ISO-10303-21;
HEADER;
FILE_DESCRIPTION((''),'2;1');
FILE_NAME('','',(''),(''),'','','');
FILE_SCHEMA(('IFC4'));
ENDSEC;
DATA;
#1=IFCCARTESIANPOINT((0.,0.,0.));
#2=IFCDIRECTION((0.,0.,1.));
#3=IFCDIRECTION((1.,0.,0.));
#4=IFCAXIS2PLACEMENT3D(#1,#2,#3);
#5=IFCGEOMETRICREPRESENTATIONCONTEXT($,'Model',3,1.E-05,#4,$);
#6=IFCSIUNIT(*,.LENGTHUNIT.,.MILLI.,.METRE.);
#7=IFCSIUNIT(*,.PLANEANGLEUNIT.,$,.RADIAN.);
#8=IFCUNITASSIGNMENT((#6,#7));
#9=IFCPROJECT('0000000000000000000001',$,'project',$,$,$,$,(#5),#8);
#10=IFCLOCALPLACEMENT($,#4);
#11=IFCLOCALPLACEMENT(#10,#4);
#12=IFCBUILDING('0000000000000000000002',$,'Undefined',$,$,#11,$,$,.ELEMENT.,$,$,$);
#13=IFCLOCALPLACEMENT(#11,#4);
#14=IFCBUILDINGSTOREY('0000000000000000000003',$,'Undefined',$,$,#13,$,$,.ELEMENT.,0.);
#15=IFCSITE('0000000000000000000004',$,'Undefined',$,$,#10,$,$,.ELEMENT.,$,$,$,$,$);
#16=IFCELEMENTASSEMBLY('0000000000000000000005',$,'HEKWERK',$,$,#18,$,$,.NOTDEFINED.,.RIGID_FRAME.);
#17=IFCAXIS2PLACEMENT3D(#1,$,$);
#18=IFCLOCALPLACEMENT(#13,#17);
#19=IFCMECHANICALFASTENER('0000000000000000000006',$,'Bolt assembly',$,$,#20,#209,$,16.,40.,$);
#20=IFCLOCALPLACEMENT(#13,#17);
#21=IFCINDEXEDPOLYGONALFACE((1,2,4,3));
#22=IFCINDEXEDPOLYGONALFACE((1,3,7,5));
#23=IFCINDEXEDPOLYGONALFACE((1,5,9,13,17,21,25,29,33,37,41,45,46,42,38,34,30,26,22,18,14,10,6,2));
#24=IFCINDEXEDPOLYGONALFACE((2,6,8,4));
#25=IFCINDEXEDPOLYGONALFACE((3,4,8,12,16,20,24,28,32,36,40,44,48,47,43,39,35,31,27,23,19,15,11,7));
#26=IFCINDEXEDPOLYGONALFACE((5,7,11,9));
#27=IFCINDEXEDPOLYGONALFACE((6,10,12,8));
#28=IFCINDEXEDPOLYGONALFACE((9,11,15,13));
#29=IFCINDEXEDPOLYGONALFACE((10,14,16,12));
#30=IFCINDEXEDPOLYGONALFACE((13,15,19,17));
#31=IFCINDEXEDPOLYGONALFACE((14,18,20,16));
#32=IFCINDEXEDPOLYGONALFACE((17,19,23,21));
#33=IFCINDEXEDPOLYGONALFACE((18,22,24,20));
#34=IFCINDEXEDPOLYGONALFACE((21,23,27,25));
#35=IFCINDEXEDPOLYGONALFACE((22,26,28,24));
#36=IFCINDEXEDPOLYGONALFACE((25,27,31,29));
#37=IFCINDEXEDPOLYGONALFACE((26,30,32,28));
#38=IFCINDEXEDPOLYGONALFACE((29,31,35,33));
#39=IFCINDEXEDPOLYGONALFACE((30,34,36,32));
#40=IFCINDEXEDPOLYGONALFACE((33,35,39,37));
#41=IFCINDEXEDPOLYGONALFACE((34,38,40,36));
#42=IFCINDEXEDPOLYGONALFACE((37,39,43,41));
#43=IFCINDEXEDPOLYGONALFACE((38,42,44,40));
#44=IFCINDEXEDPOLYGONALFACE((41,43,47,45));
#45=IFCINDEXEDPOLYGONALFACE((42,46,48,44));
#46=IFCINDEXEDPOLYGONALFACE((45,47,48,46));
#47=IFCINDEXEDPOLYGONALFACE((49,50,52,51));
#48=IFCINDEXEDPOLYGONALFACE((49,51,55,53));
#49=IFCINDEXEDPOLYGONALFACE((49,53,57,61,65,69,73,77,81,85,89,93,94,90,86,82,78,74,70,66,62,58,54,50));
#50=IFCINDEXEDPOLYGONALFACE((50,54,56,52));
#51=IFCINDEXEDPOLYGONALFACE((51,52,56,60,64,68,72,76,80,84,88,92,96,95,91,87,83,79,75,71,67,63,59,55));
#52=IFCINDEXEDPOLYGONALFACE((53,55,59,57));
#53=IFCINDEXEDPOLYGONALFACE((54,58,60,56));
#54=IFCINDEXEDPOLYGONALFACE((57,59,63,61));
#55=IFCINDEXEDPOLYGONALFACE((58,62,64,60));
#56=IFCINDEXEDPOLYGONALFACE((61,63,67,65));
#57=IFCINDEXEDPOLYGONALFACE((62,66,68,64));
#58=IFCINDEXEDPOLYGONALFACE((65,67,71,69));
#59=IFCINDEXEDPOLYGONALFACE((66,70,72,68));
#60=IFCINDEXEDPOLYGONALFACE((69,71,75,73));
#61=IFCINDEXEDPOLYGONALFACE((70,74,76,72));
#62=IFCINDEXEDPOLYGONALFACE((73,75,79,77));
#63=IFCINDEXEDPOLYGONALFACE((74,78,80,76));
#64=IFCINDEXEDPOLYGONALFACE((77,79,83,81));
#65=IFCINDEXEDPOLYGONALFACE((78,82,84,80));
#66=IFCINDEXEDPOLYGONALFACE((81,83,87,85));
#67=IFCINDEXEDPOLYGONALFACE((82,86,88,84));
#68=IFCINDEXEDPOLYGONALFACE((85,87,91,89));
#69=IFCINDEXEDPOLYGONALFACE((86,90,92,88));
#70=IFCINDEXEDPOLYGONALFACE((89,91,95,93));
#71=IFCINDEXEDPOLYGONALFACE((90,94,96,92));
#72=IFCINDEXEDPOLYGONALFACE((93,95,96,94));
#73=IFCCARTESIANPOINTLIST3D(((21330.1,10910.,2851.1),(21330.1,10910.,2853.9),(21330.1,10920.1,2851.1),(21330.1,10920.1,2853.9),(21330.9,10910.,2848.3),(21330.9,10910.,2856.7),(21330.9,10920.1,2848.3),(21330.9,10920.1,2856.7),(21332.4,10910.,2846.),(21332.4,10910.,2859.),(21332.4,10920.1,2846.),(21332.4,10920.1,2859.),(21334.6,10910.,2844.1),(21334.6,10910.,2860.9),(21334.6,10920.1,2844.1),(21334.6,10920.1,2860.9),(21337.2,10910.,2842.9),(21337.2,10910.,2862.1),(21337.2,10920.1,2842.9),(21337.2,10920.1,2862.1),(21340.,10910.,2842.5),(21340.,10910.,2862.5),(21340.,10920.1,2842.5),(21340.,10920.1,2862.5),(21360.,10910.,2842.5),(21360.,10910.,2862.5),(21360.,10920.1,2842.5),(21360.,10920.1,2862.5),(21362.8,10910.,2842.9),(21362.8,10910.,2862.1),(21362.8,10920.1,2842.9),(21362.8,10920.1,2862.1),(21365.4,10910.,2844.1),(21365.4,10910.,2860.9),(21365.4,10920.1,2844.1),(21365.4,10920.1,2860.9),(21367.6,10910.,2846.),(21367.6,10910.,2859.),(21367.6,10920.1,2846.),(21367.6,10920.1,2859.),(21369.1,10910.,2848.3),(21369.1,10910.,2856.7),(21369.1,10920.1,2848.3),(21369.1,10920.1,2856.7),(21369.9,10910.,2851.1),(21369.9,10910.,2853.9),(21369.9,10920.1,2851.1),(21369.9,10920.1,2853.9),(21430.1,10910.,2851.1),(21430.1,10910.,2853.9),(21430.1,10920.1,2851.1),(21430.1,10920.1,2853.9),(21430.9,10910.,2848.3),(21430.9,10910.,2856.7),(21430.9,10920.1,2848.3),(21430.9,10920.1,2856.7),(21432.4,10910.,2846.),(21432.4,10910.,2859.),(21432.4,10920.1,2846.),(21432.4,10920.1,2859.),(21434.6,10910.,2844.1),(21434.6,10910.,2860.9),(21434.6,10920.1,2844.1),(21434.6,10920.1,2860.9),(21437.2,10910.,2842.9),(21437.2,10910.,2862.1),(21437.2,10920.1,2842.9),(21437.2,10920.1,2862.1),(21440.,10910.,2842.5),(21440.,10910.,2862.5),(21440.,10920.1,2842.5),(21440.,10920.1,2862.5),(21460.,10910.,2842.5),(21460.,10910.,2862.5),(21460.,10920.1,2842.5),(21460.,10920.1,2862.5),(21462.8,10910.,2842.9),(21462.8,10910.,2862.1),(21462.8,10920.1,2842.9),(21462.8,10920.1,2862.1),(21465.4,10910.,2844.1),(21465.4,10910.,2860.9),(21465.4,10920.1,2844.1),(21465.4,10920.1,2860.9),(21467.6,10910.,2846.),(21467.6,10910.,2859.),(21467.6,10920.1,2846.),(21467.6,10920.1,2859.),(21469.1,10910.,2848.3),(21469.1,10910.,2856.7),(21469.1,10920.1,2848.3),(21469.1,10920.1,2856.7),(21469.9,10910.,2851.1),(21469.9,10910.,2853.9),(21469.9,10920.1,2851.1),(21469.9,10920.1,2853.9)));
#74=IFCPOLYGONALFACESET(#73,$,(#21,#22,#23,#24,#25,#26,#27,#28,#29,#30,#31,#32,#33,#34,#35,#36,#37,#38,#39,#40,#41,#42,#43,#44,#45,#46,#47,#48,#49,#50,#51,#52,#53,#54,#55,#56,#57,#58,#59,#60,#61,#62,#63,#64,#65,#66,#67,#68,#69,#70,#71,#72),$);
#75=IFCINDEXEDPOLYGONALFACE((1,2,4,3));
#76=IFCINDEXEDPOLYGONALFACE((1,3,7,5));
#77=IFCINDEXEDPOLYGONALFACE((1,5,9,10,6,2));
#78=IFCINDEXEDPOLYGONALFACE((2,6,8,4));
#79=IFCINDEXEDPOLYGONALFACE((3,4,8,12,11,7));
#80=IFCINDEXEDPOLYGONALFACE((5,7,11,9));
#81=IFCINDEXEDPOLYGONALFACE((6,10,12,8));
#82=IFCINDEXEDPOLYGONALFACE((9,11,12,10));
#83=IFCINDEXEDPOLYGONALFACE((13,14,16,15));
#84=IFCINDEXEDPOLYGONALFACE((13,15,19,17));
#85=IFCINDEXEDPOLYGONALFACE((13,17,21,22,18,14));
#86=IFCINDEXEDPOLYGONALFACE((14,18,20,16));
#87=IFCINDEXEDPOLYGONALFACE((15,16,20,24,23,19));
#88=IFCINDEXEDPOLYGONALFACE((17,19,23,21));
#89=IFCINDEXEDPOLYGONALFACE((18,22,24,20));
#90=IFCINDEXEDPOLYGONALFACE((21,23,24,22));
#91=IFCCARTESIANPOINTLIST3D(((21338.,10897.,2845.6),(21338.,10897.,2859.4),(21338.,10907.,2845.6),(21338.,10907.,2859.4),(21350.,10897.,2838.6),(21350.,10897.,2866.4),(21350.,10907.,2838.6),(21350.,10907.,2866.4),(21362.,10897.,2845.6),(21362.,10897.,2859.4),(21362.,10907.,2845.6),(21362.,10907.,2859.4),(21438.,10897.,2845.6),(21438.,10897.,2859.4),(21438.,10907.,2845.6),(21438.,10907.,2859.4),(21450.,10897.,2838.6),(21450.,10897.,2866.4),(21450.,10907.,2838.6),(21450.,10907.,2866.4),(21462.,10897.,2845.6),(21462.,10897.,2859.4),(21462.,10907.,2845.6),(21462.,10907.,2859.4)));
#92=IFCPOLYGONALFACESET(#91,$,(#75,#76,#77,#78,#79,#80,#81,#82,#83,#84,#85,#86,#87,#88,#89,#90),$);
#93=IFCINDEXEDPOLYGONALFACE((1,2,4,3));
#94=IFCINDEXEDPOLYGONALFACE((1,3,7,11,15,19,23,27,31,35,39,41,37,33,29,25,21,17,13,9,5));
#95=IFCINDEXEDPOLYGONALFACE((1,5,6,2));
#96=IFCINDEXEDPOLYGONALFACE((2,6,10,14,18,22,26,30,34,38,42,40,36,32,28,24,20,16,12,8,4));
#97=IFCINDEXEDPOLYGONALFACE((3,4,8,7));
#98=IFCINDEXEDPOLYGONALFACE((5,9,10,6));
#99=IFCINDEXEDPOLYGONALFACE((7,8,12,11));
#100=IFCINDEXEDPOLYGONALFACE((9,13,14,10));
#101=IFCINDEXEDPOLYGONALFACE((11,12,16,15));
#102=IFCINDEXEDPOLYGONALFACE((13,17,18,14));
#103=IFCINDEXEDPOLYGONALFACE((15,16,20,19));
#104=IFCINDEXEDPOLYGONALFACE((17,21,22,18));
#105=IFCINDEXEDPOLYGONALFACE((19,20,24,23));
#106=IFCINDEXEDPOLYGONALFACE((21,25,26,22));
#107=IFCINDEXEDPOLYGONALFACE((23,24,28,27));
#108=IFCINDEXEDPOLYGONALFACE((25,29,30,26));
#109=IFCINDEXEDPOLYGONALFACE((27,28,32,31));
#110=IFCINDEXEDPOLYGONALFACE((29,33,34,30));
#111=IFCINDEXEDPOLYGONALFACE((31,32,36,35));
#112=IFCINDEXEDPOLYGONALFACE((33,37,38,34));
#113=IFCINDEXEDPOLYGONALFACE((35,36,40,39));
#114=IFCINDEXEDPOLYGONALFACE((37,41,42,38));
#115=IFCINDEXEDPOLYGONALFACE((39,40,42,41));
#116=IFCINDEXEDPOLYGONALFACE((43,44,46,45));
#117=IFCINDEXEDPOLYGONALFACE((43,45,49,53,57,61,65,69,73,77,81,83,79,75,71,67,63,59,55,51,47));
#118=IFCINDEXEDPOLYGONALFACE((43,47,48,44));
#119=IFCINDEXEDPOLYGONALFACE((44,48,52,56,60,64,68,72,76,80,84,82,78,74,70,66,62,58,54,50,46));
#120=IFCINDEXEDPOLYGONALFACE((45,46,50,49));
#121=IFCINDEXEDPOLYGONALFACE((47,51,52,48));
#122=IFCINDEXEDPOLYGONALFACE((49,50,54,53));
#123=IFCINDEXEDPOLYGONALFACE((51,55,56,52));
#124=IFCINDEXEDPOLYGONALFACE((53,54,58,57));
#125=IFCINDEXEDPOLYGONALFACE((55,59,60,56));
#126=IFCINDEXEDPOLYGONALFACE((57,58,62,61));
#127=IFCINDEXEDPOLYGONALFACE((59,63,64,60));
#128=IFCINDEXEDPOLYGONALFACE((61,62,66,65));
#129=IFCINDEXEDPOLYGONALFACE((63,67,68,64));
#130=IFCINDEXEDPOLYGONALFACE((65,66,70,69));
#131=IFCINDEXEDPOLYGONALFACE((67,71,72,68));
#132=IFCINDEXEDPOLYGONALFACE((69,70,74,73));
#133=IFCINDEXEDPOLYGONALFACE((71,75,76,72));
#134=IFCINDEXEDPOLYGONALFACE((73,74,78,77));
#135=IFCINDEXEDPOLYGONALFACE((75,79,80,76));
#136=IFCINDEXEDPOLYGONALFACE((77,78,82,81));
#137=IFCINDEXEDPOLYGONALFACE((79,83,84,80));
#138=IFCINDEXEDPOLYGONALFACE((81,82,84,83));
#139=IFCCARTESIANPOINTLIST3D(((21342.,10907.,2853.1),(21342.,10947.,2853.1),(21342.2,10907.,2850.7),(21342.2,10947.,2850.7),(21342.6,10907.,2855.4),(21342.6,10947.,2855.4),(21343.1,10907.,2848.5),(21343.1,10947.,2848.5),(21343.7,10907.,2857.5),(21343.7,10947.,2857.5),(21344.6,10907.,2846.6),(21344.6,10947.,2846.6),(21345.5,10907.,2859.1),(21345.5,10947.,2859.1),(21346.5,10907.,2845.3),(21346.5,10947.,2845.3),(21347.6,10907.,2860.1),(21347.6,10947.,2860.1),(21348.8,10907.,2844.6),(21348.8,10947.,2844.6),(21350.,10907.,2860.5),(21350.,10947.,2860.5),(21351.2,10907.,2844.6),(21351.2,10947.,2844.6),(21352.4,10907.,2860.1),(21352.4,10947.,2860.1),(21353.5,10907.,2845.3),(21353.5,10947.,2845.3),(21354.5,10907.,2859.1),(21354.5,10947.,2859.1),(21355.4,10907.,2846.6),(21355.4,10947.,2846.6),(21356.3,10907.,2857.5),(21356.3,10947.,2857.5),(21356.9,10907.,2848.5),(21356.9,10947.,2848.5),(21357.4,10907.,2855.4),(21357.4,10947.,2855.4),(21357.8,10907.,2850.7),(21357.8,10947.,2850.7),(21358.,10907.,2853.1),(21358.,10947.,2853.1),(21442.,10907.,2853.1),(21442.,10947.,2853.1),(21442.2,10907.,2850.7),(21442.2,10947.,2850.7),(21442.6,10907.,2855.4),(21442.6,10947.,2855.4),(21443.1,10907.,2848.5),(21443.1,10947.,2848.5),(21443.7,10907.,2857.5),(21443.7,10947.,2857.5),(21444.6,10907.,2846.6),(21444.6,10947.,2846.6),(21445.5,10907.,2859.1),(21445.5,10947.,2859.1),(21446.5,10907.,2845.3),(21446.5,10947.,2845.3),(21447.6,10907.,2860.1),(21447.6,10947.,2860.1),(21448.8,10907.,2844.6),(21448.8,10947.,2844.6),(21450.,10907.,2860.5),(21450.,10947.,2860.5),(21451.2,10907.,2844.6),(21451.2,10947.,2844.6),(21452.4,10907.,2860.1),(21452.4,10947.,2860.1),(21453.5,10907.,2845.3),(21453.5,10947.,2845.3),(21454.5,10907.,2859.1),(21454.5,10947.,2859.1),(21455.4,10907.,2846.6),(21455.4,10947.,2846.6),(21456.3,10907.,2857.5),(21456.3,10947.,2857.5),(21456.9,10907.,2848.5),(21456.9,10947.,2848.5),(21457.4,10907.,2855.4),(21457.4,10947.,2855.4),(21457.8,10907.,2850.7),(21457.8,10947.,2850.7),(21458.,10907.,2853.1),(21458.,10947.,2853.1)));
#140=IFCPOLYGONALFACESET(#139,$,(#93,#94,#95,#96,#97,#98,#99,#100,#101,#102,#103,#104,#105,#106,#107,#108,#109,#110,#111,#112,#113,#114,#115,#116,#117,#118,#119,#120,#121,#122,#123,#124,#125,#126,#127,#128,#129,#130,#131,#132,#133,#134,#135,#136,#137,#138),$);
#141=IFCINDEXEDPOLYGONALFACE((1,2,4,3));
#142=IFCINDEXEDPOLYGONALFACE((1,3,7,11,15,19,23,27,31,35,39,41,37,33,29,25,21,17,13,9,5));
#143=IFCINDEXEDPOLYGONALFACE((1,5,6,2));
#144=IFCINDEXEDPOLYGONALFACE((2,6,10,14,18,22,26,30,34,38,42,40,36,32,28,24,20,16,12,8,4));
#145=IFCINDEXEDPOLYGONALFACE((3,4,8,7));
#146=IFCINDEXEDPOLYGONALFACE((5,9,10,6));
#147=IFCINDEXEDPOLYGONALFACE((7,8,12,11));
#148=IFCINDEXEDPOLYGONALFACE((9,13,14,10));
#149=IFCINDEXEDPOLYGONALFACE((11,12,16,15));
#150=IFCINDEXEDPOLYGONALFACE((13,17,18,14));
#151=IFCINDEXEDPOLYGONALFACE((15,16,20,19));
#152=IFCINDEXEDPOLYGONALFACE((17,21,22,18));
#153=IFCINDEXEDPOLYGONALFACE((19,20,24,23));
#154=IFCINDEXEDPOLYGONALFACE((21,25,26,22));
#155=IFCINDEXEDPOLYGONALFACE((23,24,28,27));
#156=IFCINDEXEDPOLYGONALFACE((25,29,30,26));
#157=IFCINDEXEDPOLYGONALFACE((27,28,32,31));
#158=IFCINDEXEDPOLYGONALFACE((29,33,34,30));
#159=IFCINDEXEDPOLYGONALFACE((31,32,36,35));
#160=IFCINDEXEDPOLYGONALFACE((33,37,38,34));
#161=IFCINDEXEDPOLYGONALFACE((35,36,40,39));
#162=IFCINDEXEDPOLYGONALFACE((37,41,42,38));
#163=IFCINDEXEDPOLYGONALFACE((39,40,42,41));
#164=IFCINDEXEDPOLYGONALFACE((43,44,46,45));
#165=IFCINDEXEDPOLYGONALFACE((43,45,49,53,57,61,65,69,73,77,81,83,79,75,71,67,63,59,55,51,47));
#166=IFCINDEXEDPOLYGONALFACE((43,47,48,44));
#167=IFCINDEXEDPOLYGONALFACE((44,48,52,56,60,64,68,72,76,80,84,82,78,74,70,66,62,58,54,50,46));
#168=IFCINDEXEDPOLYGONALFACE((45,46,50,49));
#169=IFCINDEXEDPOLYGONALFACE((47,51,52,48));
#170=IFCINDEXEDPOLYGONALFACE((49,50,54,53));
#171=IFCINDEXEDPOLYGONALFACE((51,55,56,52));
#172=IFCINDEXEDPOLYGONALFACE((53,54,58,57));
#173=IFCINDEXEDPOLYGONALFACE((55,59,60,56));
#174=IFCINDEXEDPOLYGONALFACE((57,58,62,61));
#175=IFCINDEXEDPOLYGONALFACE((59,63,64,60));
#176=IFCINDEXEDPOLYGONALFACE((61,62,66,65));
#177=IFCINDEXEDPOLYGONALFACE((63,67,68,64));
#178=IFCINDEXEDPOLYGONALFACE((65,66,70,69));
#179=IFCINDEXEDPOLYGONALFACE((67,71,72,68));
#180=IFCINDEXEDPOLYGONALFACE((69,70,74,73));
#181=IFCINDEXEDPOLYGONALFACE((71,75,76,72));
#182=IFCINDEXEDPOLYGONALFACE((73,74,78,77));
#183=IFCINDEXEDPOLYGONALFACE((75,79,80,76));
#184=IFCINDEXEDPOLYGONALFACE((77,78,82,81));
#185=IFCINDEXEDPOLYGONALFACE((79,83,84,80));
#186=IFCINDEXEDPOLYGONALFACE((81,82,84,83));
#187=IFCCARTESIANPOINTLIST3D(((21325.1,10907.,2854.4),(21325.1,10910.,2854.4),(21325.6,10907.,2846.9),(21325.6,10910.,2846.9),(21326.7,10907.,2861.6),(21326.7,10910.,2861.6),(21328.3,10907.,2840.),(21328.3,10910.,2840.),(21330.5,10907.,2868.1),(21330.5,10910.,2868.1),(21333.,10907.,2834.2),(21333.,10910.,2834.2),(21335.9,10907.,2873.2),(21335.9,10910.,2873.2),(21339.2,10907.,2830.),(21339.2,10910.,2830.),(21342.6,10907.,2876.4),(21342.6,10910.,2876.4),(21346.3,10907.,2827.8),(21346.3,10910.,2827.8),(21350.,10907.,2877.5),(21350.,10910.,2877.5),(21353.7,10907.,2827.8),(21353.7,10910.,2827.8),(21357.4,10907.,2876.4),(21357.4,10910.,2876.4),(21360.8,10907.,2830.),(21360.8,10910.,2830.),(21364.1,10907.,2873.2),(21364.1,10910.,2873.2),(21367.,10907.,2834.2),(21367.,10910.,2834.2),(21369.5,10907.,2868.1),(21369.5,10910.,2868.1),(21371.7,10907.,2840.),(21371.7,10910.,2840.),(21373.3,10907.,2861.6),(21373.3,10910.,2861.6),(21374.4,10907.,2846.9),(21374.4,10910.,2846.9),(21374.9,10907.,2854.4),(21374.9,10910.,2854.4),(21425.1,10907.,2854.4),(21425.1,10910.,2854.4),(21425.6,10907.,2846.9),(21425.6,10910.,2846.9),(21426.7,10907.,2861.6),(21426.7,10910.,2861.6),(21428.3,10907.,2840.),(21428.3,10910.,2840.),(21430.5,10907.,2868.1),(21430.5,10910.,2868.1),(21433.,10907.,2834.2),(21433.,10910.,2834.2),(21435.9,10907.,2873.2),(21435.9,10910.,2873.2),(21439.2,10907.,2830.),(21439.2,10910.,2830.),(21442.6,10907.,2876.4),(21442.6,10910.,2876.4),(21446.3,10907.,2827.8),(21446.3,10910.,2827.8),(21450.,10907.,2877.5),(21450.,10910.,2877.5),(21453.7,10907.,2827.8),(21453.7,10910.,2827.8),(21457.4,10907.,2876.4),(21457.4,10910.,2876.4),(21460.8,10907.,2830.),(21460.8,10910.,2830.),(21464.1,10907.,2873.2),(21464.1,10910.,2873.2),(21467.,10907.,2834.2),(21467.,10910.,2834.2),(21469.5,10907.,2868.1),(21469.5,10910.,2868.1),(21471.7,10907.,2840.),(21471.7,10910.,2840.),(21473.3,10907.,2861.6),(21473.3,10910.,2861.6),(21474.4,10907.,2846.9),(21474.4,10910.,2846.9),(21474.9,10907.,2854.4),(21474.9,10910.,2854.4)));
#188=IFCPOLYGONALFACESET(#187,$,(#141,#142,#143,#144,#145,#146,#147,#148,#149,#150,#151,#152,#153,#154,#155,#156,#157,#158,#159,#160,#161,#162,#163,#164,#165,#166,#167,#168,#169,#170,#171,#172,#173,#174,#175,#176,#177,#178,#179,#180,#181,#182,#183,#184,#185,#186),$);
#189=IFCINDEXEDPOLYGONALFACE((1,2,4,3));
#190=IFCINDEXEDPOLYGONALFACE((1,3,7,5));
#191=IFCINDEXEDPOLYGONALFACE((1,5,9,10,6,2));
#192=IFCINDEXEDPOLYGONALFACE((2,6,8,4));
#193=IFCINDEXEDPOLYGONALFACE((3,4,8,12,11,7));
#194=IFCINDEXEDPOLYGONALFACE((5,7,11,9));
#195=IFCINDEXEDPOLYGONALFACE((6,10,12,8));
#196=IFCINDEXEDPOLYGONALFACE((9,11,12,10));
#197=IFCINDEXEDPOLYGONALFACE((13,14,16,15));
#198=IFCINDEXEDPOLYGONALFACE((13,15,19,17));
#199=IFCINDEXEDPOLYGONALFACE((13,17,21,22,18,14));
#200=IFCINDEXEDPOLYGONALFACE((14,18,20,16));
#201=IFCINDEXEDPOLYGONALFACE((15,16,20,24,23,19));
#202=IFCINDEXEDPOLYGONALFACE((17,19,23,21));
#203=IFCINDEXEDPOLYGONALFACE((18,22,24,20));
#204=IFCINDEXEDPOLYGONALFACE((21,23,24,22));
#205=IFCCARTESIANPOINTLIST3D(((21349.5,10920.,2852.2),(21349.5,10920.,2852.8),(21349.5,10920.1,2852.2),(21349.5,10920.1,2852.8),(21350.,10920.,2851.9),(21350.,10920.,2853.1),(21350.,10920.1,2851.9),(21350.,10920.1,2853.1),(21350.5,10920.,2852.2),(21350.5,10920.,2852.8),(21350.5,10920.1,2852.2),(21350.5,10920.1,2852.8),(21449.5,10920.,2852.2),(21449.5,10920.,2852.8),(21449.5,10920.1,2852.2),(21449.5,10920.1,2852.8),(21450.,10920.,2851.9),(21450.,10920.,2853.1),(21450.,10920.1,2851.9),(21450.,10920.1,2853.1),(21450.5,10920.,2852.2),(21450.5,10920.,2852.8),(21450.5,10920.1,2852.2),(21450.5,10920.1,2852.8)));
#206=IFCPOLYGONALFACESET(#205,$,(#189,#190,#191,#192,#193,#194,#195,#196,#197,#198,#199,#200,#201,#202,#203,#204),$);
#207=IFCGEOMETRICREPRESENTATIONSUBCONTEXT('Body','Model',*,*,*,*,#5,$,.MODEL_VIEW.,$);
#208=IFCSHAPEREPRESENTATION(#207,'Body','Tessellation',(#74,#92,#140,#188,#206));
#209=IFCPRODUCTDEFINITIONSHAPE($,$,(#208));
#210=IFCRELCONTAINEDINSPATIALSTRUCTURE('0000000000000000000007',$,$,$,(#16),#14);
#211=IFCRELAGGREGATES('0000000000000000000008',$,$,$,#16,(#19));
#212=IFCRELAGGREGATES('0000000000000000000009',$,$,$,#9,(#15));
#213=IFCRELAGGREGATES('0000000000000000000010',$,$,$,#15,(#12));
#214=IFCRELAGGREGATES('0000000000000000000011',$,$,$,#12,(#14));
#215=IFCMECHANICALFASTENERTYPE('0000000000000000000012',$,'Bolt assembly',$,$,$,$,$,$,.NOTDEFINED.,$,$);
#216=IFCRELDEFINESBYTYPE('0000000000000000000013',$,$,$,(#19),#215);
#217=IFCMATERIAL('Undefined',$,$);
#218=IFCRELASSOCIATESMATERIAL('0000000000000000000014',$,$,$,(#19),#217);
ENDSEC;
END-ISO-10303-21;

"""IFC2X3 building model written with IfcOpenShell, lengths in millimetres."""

from ifc_helpers import new_model, si_unit, frame, frame_2d, origin_with_axes, origin_2d_with_axis, place, context, subcontext, project, spatial, polyline, circle_curve, parameter, trimmed, segment, composite_curve, circle, outline, extrude, source, transform, mapped, material, type_object, element, aggregate, save


model = new_model("IFC2X3")

# Units and contexts
model_context = context("Model", 3, precision=1e-05, world=origin_with_axes())
body_context = subcontext(model_context, "Body", "Model", "MODEL_VIEW")
ifc_project = project(units=[si_unit("LENGTHUNIT", "METRE", prefix="MILLI"), si_unit("PLANEANGLEUNIT", "RADIAN")], contexts=[model_context])

# Site, building, storey
site_placement = place(None, origin_with_axes())
site = spatial("IfcSite", under=ifc_project, at=site_placement, Name="Undefined", CompositionType="ELEMENT")
building_placement = place(site_placement, origin_with_axes())
building = spatial("IfcBuilding", under=site, at=building_placement, Name="Undefined", CompositionType="ELEMENT")
storey_placement = place(building_placement, origin_with_axes())
storey = spatial("IfcBuildingStorey", under=building, at=storey_placement, Name="Undefined", CompositionType="ELEMENT", Elevation=0.0)

# Element assembly
assembly_1_placement = place(storey_placement, origin_with_axes())
assembly_1 = element("IfcElementAssembly", 1, at=assembly_1_placement, inside=storey, Name="HEKWERK", AssemblyPlace="NOTDEFINED", PredefinedType="RIGID_FRAME")

# Mechanical fastener
ifc_material_1 = material(Name="Undefined")
mechanical_fastener_type = type_object("IfcMechanicalFastenerType", Name="Bolt assembly")
shared_shape_1 = source(origin_with_axes(), body_context, "Body", "SweptSolid", [
    extrude(outline(composite_curve([segment(polyline([(10.0, 10.0), (10.0, -10.0)]), True, "CONTINUOUS"), segment(trimmed(circle_curve(frame_2d((0.0, -10.0), x_axis=(1.0, 0.0)), 10.0), [parameter(0.0)], [parameter(3.141593)], False, "PARAMETER"), True, "CONTINUOUS"), segment(polyline([(-10.0, -10.0), (-10.0, 10.0)]), True, "CONTINUOUS"), segment(trimmed(circle_curve(frame_2d((0.0, 10.0), x_axis=(-1.0, 0.0)), 10.0), [parameter(0.0)], [parameter(3.141593)], False, "PARAMETER"), True, "DISCONTINUOUS")], self_intersect=False)), frame((0.0, 30.0, 0.0), z_axis=(0.0, 1.0, 0.0), x_axis=(1.0, 0.0, 0.0)), (0.0, 0.0, 1.0), 10.1),
    extrude(outline(polyline([(13.9, 0.0), (6.9, 12.0), (-6.9, 12.0), (-13.9, 0.0), (-6.9, -12.0), (6.9, -12.0), (13.9, 0.0)])), frame((0.0, 17.0, 0.0), z_axis=(0.0, 1.0, 0.0), x_axis=(1.0, 0.0, 0.0)), (0.0, 0.0, 1.0), 10.0),
    extrude(circle(Radius=8.0, at=origin_2d_with_axis()), frame((0.0, 27.0, 0.0), z_axis=(0.0, 1.0, 0.0), x_axis=(1.0, 0.0, 0.0)), (0.0, 0.0, 1.0), 40.0),
    extrude(circle(Radius=25.0, at=origin_2d_with_axis()), frame((0.0, 27.0, 0.0), z_axis=(0.0, 1.0, 0.0), x_axis=(1.0, 0.0, 0.0)), (0.0, 0.0, 1.0), 3.0),
    extrude(outline(polyline([(0.6, 0.0), (0.3, 0.5), (-0.3, 0.5), (-0.6, 0.0), (-0.3, -0.5), (0.3, -0.5), (0.6, 0.0)])), frame((0.0, 40.0, 0.0), z_axis=(0.0, 1.0, 0.0), x_axis=(1.0, 0.0, 0.0)), (0.0, 0.0, 1.0), 0.1),
])
mechanical_fastener_1_placement = place(assembly_1_placement, frame((21400.0, 10880.0, 2852.5), z_axis=(-1.0, 0.0, 0.0), x_axis=(0.0, 0.0, 1.0)))
mechanical_fastener_1 = element("IfcMechanicalFastener", 2, at=mechanical_fastener_1_placement, type_object=mechanical_fastener_type, material=ifc_material_1, Name="Bolt assembly", NominalDiameter=16.0, NominalLength=40.0, context=body_context, shape_type="MappedRepresentation", body=[
    mapped(shared_shape_1, transform((0.0, 0.0, -50.0))),
    mapped(shared_shape_1, transform((0.0, 0.0, 50.0))),
])
aggregate(assembly_1, [mechanical_fastener_1])

save(model, "model.ifc")
